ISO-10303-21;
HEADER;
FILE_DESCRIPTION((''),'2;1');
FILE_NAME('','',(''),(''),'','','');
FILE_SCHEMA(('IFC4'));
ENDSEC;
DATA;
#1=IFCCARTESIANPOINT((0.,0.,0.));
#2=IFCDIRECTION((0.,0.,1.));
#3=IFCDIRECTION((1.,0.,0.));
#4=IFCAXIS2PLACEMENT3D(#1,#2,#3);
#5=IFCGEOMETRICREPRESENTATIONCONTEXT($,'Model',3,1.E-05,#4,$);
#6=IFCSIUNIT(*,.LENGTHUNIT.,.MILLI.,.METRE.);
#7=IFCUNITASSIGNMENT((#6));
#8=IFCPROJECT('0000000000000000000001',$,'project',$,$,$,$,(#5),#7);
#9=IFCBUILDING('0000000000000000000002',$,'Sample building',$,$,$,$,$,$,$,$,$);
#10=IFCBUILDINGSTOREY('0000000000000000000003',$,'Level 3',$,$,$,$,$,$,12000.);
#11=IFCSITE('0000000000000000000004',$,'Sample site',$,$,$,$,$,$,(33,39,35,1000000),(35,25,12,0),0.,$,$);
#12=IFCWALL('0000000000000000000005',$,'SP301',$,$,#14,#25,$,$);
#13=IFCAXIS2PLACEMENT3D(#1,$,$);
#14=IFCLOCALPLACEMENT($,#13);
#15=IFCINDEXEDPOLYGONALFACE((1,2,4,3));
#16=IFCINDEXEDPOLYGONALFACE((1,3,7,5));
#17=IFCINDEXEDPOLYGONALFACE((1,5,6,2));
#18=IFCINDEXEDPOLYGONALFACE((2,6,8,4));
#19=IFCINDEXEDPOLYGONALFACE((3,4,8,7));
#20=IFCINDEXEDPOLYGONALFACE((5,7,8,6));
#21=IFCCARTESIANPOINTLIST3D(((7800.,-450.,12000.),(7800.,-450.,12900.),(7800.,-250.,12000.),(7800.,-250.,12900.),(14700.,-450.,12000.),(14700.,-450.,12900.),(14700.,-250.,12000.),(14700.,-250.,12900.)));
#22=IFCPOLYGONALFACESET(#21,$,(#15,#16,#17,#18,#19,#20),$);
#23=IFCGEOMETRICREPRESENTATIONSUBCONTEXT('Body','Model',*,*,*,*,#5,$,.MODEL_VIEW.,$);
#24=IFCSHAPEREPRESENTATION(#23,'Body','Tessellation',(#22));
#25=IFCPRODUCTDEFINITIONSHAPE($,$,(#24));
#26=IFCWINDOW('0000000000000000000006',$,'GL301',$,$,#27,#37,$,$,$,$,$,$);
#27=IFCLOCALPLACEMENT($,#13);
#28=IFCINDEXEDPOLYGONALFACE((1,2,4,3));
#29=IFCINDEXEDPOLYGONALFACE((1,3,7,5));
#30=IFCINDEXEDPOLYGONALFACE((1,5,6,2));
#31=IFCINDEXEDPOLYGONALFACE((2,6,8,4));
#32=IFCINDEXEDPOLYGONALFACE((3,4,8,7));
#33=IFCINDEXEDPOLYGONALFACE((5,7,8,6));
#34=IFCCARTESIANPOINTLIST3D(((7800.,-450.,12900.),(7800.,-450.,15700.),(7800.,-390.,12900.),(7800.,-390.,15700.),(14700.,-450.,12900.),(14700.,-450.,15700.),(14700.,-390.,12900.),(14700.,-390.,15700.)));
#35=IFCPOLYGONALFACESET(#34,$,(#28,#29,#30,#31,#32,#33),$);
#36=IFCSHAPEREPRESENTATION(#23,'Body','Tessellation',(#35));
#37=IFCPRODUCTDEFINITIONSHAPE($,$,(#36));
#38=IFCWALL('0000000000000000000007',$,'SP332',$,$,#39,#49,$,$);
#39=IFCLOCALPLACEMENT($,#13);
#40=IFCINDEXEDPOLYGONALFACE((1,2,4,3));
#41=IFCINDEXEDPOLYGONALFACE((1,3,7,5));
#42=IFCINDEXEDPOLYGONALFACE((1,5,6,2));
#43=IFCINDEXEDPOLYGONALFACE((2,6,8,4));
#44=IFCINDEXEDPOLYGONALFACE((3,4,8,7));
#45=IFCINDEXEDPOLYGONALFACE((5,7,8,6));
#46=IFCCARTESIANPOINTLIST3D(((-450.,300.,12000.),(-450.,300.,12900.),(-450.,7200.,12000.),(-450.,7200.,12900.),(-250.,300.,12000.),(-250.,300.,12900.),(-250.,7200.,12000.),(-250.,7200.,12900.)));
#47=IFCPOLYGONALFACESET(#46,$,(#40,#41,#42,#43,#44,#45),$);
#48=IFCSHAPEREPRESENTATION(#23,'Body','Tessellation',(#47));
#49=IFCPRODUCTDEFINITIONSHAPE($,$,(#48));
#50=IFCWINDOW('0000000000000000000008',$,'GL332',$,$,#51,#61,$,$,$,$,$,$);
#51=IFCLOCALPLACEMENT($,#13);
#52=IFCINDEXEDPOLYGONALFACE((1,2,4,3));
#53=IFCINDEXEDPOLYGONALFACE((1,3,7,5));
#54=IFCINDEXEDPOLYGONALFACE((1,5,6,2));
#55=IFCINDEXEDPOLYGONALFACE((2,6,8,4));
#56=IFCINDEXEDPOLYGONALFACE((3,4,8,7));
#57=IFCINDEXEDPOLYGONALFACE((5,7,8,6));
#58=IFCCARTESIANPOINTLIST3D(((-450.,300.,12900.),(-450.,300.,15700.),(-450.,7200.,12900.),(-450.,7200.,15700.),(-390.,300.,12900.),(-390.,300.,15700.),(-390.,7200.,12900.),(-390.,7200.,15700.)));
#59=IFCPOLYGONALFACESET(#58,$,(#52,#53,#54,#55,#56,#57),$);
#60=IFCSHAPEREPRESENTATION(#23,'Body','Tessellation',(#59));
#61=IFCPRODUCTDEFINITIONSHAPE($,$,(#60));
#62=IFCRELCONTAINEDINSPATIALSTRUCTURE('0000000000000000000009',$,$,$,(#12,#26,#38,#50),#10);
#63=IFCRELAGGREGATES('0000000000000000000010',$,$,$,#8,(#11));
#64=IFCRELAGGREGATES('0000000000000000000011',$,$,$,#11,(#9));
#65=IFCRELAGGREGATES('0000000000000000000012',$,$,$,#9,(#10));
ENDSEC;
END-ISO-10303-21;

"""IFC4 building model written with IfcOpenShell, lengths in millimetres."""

from ifc_helpers import new_model, si_unit, frame, origin_with_axes, place, context, subcontext, project, spatial, indexed_curve, outline, extrude, element, save


model = new_model("IFC4")

# Units and contexts
model_context = context("Model", 3, precision=1e-05, world=origin_with_axes())
body_context = subcontext(model_context, "Body", "Model", "MODEL_VIEW")
ifc_project = project(units=[si_unit("LENGTHUNIT", "METRE", prefix="MILLI")], contexts=[model_context])

# Site, building, storey
site = spatial("IfcSite", under=ifc_project, Name="Sample site", RefLatitude=(33, 39, 35, 1000000), RefLongitude=(35, 25, 12, 0), RefElevation=0.0)
building = spatial("IfcBuilding", under=site, Name="Sample building")
storey = spatial("IfcBuildingStorey", under=building, Name="Level 3", Elevation=12000.0)

# Wall
wall_1_placement = place(None, frame((7800.0, -450.0, 12000.0), z_axis=(0.0, 0.0, 1.0), x_axis=(1.0, 0.0, 0.0)))
element("IfcWall", 1, at=wall_1_placement, inside=storey, Name="SP301", context=body_context, shape_type="SweptSolid", body=[
    extrude(outline(indexed_curve([(0.0, 0.0), (0.0, 200.0), (6900.0, 200.0), (6900.0, 0.0), (0.0, 0.0)], self_intersect=False)), origin_with_axes(), (0.0, 0.0, 1.0), 900.0),
])

# Window
window_1_placement = place(None, frame((7800.0, -450.0, 12900.0), z_axis=(0.0, 0.0, 1.0), x_axis=(1.0, 0.0, 0.0)))
element("IfcWindow", 2, at=window_1_placement, inside=storey, Name="GL301", context=body_context, shape_type="SweptSolid", body=[
    extrude(outline(indexed_curve([(0.0, 0.0), (0.0, 60.0), (6900.0, 60.0), (6900.0, 0.0), (0.0, 0.0)], self_intersect=False)), origin_with_axes(), (0.0, 0.0, 1.0), 2800.0),
])

# Wall
wall_2_placement = place(None, frame((-450.0, 7200.0, 12000.0), z_axis=(0.0, 0.0, 1.0), x_axis=(0.0, -1.0, 0.0)))
element("IfcWall", 3, at=wall_2_placement, inside=storey, Name="SP332", context=body_context, shape_type="SweptSolid", body=[
    extrude(outline(indexed_curve([(0.0, 0.0), (0.0, 200.0), (6900.0, 200.0), (6900.0, 0.0), (0.0, 0.0)], self_intersect=False)), origin_with_axes(), (0.0, 0.0, 1.0), 900.0),
])

# Window
window_2_placement = place(None, frame((-450.0, 7200.0, 12900.0), z_axis=(0.0, 0.0, 1.0), x_axis=(0.0, -1.0, 0.0)))
element("IfcWindow", 4, at=window_2_placement, inside=storey, Name="GL332", context=body_context, shape_type="SweptSolid", body=[
    extrude(outline(indexed_curve([(0.0, 0.0), (0.0, 60.0), (6900.0, 60.0), (6900.0, 0.0), (0.0, 0.0)], self_intersect=False)), origin_with_axes(), (0.0, 0.0, 1.0), 2800.0),
])

save(model, "model.ifc")
